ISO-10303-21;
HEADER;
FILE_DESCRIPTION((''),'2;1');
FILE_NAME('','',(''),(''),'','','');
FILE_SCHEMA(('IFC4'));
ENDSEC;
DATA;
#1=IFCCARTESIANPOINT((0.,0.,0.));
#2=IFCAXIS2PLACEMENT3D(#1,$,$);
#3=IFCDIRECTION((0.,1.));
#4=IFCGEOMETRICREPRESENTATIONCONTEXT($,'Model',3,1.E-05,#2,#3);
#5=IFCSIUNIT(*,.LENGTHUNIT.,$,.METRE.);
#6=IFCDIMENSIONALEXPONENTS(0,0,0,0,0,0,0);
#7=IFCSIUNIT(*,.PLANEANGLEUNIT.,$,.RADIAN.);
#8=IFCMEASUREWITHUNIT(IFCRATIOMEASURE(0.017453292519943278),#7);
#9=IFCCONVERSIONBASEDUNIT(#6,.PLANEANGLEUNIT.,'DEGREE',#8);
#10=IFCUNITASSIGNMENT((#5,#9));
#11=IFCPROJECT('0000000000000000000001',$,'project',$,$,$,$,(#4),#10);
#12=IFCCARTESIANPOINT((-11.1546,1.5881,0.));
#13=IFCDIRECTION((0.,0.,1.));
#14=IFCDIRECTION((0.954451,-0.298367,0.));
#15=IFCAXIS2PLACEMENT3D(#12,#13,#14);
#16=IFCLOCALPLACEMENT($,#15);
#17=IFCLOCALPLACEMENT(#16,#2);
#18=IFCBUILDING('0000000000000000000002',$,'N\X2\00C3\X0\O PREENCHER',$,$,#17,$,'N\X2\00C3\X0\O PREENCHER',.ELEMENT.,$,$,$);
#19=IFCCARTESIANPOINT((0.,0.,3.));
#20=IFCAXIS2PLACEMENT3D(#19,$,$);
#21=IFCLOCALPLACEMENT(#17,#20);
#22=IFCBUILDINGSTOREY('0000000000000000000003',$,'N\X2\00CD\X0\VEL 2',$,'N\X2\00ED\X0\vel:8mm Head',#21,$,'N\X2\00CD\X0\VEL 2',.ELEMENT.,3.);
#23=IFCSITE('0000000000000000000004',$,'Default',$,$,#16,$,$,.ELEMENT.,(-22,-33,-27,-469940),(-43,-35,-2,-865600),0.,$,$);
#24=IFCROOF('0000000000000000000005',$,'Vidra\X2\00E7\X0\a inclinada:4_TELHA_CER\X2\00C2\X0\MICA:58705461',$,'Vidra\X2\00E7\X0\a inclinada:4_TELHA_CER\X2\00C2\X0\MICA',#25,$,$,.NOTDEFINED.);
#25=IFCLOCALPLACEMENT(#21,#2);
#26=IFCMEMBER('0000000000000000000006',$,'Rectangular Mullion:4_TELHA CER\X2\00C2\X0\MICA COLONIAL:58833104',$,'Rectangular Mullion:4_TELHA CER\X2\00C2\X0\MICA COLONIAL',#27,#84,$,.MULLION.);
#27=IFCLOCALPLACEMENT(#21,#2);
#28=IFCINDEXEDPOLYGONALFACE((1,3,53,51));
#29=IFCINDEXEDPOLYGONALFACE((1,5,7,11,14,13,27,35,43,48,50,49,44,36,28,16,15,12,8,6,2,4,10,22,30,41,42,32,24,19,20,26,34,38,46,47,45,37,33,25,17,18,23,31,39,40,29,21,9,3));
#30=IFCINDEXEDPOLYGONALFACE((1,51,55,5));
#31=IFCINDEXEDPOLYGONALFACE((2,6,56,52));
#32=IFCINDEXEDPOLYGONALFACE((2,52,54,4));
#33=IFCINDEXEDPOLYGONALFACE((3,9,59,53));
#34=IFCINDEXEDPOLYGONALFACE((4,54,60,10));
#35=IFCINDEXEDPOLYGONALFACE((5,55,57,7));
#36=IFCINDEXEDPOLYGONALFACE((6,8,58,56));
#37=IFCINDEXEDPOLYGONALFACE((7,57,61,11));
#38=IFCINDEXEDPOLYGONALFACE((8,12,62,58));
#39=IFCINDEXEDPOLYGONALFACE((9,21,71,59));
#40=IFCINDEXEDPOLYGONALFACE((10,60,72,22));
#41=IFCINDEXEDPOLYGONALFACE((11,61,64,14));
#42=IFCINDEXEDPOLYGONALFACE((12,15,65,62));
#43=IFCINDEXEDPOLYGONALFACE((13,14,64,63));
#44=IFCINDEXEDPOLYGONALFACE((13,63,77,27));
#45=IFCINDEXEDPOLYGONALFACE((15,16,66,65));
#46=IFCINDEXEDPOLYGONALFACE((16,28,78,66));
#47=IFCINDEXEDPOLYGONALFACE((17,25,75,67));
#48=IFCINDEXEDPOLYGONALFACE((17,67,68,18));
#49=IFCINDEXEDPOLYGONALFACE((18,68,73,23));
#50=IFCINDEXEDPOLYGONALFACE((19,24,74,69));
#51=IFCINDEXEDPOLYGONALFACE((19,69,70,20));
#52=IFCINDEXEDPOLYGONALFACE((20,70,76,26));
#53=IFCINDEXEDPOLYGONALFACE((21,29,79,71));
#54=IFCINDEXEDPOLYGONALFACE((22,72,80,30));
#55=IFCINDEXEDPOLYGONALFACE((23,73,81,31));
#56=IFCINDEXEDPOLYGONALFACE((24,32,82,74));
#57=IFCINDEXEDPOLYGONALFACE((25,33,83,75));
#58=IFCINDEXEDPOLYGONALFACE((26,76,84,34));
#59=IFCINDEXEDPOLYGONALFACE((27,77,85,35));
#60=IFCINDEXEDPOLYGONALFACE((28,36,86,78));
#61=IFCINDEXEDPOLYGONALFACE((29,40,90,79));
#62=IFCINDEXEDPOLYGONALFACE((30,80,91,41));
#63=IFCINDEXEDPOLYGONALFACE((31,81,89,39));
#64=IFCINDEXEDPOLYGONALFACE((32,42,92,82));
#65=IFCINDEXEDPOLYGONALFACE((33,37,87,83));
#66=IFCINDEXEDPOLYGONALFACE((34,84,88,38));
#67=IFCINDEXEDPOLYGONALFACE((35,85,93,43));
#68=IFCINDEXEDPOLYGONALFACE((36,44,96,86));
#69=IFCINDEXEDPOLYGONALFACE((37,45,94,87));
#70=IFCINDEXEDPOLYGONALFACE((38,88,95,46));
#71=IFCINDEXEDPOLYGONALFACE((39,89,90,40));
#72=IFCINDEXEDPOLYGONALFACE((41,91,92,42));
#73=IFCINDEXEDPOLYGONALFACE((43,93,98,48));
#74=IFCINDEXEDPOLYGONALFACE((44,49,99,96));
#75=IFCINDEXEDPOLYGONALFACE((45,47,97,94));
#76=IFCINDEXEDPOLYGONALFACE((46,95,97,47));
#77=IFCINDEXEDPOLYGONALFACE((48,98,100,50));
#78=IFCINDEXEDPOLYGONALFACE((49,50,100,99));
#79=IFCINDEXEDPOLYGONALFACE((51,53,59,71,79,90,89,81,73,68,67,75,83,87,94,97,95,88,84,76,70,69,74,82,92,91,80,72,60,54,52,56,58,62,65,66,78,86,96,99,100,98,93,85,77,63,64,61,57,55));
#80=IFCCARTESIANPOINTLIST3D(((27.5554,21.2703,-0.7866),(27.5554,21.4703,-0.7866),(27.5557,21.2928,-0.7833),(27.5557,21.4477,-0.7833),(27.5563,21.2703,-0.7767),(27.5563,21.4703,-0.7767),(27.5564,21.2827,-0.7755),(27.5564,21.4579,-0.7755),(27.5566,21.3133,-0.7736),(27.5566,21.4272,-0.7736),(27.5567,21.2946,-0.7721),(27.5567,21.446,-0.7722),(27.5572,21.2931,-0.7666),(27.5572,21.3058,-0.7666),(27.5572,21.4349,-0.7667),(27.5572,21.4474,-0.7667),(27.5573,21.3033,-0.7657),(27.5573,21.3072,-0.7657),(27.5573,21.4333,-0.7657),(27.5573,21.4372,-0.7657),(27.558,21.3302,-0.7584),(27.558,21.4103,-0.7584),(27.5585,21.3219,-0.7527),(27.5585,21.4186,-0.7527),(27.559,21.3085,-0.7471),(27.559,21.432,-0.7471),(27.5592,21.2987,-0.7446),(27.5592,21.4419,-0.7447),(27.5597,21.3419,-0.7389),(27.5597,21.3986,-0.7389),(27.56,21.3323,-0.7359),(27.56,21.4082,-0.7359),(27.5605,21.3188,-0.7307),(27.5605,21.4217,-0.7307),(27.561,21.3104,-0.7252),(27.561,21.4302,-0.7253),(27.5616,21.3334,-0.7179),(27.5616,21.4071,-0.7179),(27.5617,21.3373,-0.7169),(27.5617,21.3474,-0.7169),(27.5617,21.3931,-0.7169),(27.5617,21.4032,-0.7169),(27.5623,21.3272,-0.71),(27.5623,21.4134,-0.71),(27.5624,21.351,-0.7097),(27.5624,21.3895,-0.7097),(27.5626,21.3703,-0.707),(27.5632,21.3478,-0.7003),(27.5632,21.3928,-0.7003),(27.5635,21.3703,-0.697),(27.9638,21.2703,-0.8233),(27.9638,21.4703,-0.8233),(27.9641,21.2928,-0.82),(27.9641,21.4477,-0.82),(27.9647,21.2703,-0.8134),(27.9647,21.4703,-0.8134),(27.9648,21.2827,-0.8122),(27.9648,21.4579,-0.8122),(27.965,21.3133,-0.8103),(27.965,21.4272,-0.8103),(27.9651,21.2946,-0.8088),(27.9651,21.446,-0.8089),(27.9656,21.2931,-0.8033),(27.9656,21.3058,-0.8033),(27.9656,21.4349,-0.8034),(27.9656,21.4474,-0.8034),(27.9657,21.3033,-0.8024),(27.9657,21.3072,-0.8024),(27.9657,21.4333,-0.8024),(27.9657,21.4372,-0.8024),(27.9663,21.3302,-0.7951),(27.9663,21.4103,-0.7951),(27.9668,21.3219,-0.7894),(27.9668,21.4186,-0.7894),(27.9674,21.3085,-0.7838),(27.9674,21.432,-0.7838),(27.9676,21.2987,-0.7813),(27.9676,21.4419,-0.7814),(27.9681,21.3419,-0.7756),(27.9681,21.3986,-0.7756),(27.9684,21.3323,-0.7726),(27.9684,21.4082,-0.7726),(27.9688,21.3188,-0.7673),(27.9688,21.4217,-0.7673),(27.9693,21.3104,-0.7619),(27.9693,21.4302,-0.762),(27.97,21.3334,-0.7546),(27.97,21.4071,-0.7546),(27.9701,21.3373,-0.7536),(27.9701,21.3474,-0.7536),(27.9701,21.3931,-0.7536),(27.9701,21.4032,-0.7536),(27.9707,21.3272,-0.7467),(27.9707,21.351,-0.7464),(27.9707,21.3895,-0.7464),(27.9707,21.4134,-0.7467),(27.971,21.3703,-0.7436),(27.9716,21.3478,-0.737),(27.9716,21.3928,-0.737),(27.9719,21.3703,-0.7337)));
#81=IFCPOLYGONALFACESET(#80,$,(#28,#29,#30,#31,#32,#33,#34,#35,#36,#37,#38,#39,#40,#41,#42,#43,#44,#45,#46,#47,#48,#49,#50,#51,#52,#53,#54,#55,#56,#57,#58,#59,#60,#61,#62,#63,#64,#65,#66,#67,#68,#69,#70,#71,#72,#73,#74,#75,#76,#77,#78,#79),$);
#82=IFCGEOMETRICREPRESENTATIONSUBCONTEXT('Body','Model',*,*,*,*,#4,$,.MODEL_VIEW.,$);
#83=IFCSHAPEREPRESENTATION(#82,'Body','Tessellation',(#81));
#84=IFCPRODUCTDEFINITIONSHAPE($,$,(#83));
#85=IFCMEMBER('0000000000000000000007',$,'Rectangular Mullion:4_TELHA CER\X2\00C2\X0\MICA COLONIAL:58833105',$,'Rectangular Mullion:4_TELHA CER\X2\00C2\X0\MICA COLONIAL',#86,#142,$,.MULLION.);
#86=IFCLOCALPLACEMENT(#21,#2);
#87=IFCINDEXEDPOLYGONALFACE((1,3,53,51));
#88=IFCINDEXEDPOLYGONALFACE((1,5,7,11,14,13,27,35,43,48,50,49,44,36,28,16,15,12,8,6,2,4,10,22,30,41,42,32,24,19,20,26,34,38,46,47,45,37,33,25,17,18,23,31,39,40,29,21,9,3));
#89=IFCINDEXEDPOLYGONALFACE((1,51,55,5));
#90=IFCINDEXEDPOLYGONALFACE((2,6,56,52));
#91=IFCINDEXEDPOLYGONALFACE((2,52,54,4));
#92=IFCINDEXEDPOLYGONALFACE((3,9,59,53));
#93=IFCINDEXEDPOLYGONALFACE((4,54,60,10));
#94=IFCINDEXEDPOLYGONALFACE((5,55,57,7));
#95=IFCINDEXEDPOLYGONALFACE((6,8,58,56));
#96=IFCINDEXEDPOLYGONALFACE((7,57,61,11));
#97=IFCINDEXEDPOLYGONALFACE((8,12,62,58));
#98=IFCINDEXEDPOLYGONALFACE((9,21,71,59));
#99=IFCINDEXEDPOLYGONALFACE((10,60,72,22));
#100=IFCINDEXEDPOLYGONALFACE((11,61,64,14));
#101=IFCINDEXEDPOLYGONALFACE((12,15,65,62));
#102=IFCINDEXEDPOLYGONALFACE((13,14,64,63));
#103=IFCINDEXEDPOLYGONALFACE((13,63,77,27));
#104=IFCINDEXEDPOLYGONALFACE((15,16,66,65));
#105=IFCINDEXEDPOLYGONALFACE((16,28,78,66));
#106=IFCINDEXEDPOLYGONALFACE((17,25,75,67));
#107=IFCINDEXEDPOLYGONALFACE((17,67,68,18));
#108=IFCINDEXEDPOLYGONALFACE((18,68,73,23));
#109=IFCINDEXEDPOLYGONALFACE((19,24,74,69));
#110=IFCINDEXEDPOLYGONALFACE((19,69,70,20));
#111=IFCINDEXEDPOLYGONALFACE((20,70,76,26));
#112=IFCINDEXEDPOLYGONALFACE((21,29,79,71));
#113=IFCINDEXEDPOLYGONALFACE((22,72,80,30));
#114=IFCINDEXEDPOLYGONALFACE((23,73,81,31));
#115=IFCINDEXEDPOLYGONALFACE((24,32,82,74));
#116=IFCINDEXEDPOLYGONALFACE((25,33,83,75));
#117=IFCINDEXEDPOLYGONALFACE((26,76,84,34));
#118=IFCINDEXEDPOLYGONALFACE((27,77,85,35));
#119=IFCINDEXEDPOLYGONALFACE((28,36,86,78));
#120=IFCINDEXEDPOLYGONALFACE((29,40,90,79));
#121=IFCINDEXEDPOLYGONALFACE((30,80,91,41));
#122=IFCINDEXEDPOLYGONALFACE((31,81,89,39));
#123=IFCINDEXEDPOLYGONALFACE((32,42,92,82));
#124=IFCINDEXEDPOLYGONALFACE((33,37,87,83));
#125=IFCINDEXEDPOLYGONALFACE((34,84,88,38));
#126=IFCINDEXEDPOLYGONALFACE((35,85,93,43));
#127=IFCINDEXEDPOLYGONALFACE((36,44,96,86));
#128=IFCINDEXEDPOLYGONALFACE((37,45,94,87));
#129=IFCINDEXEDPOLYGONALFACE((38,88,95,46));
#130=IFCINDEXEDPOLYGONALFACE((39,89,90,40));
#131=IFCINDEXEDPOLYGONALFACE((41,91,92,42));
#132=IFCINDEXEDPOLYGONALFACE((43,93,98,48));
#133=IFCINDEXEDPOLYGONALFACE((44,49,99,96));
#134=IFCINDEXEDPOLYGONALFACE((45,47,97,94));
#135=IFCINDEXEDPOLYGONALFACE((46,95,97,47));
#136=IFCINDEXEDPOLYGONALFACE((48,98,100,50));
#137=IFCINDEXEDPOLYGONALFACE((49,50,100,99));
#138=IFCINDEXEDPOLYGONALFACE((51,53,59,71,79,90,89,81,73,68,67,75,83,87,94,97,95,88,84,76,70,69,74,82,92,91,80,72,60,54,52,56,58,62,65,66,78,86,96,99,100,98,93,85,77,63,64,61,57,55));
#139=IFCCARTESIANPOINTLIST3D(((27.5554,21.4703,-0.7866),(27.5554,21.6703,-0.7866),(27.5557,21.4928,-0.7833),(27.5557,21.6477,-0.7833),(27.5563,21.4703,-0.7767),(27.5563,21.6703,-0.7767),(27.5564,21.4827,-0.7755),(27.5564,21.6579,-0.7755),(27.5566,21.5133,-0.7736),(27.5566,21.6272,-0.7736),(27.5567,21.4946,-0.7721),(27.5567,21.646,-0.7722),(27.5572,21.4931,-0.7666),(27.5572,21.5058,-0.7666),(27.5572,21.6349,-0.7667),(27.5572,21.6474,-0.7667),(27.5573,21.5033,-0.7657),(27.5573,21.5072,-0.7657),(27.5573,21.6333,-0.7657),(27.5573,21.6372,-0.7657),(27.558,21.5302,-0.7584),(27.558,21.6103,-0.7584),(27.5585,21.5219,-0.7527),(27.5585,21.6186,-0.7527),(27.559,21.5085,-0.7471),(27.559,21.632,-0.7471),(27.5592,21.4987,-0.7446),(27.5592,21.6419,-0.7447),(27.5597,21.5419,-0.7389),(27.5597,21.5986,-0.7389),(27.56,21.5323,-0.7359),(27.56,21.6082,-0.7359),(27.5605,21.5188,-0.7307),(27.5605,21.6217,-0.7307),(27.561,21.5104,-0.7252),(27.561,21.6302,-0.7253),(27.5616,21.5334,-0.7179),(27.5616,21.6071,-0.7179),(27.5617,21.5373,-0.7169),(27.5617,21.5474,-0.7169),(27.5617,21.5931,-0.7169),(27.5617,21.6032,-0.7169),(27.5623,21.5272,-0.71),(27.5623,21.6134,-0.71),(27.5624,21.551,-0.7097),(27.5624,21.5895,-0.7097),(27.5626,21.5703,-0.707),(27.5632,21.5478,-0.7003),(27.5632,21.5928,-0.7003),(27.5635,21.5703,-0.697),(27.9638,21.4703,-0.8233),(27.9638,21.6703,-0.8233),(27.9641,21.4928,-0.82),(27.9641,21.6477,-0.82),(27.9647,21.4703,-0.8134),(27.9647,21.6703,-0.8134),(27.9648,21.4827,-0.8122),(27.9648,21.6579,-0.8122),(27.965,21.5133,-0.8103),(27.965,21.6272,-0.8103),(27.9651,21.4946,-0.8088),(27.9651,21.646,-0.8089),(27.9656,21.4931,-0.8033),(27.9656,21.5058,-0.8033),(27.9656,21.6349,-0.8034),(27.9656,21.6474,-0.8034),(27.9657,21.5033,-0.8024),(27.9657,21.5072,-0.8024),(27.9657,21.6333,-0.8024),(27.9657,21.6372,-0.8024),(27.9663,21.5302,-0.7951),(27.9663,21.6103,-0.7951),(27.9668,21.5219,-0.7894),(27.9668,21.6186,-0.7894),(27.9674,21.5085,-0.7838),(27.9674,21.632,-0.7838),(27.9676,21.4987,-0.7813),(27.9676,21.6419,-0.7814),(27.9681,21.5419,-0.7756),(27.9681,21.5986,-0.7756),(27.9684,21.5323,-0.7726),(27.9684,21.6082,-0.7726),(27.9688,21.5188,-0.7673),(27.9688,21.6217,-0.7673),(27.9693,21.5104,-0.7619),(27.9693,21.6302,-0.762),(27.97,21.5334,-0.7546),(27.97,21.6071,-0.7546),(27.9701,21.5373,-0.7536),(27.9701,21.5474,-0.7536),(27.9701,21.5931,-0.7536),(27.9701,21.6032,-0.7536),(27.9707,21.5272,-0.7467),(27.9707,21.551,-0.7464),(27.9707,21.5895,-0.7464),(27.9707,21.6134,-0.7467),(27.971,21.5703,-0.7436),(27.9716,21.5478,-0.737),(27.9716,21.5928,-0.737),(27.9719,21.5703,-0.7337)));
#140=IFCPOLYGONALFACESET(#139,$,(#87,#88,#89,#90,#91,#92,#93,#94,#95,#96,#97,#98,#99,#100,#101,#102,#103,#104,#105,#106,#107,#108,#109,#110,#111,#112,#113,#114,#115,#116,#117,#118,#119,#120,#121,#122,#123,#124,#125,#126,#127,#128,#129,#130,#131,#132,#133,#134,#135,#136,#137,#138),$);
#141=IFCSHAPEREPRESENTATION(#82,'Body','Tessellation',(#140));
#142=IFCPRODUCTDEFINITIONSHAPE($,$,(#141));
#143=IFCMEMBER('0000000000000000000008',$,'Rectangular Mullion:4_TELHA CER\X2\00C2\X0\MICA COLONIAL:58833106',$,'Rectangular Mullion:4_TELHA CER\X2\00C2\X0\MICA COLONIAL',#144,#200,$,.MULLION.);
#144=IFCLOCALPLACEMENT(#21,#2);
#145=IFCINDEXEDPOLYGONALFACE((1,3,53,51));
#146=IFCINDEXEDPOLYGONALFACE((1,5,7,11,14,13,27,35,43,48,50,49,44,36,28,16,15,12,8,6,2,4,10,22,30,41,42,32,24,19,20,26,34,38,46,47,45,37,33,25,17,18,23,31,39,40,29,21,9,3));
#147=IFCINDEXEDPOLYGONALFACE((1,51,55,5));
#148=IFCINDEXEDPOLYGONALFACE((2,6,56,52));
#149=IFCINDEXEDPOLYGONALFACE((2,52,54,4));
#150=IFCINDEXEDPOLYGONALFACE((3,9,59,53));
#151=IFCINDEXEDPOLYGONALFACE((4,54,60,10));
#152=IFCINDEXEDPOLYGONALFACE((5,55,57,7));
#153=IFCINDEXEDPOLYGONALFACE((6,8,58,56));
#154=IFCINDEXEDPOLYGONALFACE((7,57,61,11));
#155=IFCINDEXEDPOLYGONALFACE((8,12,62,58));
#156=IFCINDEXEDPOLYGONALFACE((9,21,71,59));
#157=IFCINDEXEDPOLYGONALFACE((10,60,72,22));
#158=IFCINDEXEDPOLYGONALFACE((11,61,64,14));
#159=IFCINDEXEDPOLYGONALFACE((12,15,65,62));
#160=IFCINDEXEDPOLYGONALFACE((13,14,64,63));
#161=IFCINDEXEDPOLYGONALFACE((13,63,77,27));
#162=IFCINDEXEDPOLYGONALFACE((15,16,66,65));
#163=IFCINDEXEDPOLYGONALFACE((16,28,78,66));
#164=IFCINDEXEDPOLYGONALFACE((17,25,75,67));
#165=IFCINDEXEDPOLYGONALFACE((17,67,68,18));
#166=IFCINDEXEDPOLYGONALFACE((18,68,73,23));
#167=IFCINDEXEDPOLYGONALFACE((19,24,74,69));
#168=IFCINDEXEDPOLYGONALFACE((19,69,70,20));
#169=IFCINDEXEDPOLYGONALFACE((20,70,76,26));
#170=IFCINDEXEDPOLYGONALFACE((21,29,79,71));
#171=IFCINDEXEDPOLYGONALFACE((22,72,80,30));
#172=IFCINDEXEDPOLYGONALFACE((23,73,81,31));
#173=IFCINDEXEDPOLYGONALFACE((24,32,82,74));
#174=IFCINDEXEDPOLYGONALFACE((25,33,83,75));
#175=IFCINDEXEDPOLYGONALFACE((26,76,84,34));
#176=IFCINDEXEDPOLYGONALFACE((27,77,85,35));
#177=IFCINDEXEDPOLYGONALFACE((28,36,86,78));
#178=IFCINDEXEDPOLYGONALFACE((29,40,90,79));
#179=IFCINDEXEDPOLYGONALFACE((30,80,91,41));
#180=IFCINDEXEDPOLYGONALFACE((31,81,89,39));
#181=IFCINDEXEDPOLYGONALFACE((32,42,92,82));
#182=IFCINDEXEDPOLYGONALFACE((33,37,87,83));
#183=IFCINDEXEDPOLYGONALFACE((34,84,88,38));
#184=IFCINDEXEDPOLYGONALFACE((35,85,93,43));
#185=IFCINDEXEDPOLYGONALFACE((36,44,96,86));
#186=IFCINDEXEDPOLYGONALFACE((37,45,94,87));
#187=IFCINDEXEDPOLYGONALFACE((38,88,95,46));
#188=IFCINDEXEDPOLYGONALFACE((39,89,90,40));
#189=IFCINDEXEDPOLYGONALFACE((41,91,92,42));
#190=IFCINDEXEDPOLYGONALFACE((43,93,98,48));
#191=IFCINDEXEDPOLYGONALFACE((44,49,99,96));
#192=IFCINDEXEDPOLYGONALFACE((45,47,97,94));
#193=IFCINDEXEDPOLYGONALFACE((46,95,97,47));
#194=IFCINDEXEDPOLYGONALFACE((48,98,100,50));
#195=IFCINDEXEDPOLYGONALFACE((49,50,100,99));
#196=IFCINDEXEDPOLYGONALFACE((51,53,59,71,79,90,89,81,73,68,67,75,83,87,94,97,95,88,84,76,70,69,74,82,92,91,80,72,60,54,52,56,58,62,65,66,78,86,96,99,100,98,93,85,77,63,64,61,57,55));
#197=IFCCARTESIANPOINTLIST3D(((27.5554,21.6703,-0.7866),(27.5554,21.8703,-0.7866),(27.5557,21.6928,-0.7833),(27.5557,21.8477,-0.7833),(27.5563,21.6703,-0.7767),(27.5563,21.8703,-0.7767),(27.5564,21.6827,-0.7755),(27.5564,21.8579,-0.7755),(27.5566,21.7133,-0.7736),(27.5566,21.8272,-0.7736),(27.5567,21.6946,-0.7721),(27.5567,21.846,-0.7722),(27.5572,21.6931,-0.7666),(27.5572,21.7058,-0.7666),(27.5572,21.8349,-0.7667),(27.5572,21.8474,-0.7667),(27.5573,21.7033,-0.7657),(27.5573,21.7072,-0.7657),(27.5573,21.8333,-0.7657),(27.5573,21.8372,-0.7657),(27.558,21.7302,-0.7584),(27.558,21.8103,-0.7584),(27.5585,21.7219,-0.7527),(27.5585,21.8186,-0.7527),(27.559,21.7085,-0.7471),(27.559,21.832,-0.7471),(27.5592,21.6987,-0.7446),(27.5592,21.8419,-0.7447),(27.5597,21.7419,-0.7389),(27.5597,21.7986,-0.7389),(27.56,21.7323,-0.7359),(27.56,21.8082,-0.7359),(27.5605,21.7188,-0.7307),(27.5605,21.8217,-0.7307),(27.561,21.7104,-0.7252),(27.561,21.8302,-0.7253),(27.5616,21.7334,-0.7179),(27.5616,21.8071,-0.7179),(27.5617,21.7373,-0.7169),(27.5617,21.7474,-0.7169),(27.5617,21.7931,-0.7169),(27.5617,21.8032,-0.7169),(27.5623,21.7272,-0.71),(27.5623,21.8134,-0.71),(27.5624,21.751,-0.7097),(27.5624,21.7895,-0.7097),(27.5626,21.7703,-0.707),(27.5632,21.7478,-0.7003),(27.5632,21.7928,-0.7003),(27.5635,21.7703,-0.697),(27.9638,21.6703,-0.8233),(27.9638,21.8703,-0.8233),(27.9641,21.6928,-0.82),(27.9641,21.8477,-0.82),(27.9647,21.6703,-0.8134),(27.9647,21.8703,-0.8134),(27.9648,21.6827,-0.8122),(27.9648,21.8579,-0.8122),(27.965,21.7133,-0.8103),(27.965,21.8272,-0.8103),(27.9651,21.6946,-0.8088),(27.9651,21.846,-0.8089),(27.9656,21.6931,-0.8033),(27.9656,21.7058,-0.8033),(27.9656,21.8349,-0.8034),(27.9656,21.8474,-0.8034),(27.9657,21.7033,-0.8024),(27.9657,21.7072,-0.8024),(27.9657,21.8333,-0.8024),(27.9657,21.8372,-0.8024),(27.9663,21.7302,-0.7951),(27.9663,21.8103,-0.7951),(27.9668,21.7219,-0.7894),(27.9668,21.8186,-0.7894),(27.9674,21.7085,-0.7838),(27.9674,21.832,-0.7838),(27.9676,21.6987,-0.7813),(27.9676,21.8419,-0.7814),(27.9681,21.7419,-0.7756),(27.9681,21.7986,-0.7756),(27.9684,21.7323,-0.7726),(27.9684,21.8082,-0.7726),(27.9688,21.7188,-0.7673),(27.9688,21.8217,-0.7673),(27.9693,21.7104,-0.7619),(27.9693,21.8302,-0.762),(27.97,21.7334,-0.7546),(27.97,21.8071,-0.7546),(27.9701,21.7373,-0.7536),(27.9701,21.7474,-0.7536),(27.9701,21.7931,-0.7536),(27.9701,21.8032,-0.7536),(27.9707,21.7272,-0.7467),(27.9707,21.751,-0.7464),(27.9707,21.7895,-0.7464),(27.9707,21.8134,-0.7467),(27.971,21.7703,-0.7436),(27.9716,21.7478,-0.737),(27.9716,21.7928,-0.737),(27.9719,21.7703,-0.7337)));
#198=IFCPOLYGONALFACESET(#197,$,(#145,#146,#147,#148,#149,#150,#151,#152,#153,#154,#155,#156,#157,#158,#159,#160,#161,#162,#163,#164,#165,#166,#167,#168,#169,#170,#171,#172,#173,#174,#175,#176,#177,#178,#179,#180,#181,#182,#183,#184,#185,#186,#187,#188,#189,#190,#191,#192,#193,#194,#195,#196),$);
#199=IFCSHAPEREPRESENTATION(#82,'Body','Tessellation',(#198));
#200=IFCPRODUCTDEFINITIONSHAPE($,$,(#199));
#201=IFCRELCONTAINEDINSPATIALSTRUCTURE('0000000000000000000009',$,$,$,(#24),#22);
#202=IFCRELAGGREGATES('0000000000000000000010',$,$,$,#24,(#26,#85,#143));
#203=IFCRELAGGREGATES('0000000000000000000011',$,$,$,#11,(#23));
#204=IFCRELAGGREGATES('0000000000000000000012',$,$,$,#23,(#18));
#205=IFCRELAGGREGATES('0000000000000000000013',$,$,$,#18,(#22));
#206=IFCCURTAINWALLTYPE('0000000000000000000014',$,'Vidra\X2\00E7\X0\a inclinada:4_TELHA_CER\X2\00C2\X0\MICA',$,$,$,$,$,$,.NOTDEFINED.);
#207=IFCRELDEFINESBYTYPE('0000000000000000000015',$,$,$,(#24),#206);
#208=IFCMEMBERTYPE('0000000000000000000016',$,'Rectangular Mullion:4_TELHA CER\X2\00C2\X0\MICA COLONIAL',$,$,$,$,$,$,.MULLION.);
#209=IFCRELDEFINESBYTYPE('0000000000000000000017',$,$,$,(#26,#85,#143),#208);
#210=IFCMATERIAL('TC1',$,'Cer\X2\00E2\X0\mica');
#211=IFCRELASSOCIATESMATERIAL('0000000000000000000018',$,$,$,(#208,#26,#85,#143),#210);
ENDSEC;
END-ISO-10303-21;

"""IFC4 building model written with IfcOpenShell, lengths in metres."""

from ifc_helpers import new_model, entity, si_unit, converted_unit, direction, frame, origin, place, context, subcontext, project, spatial, line, arc, indexed_curve, outline, extrude, source, transform, mapped, material, type_object, type_shapes, element, aggregate, save


model = new_model("IFC4")

# Units and contexts
model_context = context("Model", 3, precision=1e-05, world=origin(), true_north=direction((0.0, 1.0)))
body_context = subcontext(model_context, "Body", "Model", "MODEL_VIEW")
ifc_project = project(units=[si_unit("LENGTHUNIT", "METRE"), converted_unit("PLANEANGLEUNIT", "DEGREE", entity("IfcRatioMeasure", 0.017453292519943278), si_unit("PLANEANGLEUNIT", "RADIAN"), dimensions=[0, 0, 0, 0, 0, 0, 0])], contexts=[model_context])

# Site, building, storey
site_placement = place(None, frame((-11.1546, 1.5881, 0.0), z_axis=(0.0, 0.0, 1.0), x_axis=(0.954451, -0.298367, 0.0)))
site = spatial("IfcSite", under=ifc_project, at=site_placement, Name="Default", CompositionType="ELEMENT", RefLatitude=(-22, -33, -27, -469940), RefLongitude=(-43, -35, -2, -865600), RefElevation=0.0)
building_placement = place(site_placement, origin())
building = spatial("IfcBuilding", under=site, at=building_placement, Name="NÃO PREENCHER", LongName="NÃO PREENCHER", CompositionType="ELEMENT")
storey_placement = place(building_placement, frame((0.0, 0.0, 3.0)))
storey = spatial("IfcBuildingStorey", under=building, at=storey_placement, Name="NÍVEL 2", ObjectType="Nível:8mm Head", LongName="NÍVEL 2", CompositionType="ELEMENT", Elevation=3.0)

# Roof, members
curtain_wall_type = type_object("IfcCurtainWallType", Name="Vidraça inclinada:4_TELHA_CERÂMICA", PredefinedType="NOTDEFINED")
roof_placement = place(storey_placement, frame((0.0, 0.0, -3.0)))
roof = element("IfcRoof", 1, at=roof_placement, inside=storey, type_object=curtain_wall_type, Name="Vidraça inclinada:4_TELHA_CERÂMICA:58705461", ObjectType="Vidraça inclinada:4_TELHA_CERÂMICA", PredefinedType="NOTDEFINED")
ifc_material = material(Name="TC1", Category="Cerâmica")
member_type_1 = type_object("IfcMemberType", Name="Rectangular Mullion:4_TELHA CERÂMICA COLONIAL", PredefinedType="MULLION", material=ifc_material)
shared_shape_1 = source(origin(), body_context, "Body", "SweptSolid", [
    extrude(outline(indexed_curve([(-0.029, -0.1), (-0.019, -0.1), (-0.0164, -0.0815), (-0.0089, -0.0645), (-0.0089, -0.0771), (0.061, 0.0), (-0.009, 0.0771), (-0.009, 0.0646), (-0.0165, 0.0816), (-0.019, 0.1), (-0.029, 0.1), (-0.0089, 0.0479), (0.041, 0.0229), (0.041, 0.0329), (0.0131, 0.0425), (-0.008, 0.0631), (-0.008, 0.067), (0.051, 0.0), (-0.008, -0.067), (-0.008, -0.0631), (0.0131, -0.0425), (0.041, -0.0329), (0.041, -0.0229), (-0.0089, -0.0479)], segments=[line(1, 2), arc(2, 3, 4), line(4, 5), arc(5, 6, 7), line(7, 8), arc(8, 9, 10), line(10, 11), arc(11, 12, 13), line(13, 14), arc(14, 15, 16), line(16, 17), arc(17, 18, 19), line(19, 20), arc(20, 21, 22), line(22, 23), arc(23, 24, 1)], self_intersect=False)), frame((0.0, -0.029, -0.41), z_axis=(0.0, 0.0, 1.0), x_axis=(0.0, -1.0, 0.0)), (0.0, 0.0, 1.0), 0.41),
])
type_shapes(member_type_1, [shared_shape_1])
member_1_placement = place(roof_placement, frame((27.5554, 21.3703, 2.2134), z_axis=(-0.99599, 0.0, 0.089469), x_axis=(0.0, 1.0, 0.0)))
member_1 = element("IfcMember", 2, at=member_1_placement, type_object=member_type_1, material=ifc_material, Name="Rectangular Mullion:4_TELHA CERÂMICA COLONIAL:58833104", ObjectType="Rectangular Mullion:4_TELHA CERÂMICA COLONIAL", PredefinedType="MULLION", context=body_context, shape_type="MappedRepresentation", body=[
    mapped(shared_shape_1, transform((0.0, 0.0, 0.0), scale=1.0)),
])
member_2_placement = place(roof_placement, frame((27.5554, 21.5703, 2.2134), z_axis=(-0.99599, 0.0, 0.089469), x_axis=(0.0, 1.0, 0.0)))
member_2 = element("IfcMember", 3, at=member_2_placement, type_object=member_type_1, material=ifc_material, Name="Rectangular Mullion:4_TELHA CERÂMICA COLONIAL:58833105", ObjectType="Rectangular Mullion:4_TELHA CERÂMICA COLONIAL", PredefinedType="MULLION", context=body_context, shape_type="MappedRepresentation", body=[
    mapped(shared_shape_1, transform((0.0, 0.0, 0.0), scale=1.0)),
])
member_3_placement = place(roof_placement, frame((27.5554, 21.7703, 2.2134), z_axis=(-0.99599, 0.0, 0.089469), x_axis=(0.0, 1.0, 0.0)))
member_3 = element("IfcMember", 4, at=member_3_placement, type_object=member_type_1, material=ifc_material, Name="Rectangular Mullion:4_TELHA CERÂMICA COLONIAL:58833106", ObjectType="Rectangular Mullion:4_TELHA CERÂMICA COLONIAL", PredefinedType="MULLION", context=body_context, shape_type="MappedRepresentation", body=[
    mapped(shared_shape_1, transform((0.0, 0.0, 0.0), scale=1.0)),
])
aggregate(roof, [member_1, member_2, member_3])

save(model, "model.ifc")
